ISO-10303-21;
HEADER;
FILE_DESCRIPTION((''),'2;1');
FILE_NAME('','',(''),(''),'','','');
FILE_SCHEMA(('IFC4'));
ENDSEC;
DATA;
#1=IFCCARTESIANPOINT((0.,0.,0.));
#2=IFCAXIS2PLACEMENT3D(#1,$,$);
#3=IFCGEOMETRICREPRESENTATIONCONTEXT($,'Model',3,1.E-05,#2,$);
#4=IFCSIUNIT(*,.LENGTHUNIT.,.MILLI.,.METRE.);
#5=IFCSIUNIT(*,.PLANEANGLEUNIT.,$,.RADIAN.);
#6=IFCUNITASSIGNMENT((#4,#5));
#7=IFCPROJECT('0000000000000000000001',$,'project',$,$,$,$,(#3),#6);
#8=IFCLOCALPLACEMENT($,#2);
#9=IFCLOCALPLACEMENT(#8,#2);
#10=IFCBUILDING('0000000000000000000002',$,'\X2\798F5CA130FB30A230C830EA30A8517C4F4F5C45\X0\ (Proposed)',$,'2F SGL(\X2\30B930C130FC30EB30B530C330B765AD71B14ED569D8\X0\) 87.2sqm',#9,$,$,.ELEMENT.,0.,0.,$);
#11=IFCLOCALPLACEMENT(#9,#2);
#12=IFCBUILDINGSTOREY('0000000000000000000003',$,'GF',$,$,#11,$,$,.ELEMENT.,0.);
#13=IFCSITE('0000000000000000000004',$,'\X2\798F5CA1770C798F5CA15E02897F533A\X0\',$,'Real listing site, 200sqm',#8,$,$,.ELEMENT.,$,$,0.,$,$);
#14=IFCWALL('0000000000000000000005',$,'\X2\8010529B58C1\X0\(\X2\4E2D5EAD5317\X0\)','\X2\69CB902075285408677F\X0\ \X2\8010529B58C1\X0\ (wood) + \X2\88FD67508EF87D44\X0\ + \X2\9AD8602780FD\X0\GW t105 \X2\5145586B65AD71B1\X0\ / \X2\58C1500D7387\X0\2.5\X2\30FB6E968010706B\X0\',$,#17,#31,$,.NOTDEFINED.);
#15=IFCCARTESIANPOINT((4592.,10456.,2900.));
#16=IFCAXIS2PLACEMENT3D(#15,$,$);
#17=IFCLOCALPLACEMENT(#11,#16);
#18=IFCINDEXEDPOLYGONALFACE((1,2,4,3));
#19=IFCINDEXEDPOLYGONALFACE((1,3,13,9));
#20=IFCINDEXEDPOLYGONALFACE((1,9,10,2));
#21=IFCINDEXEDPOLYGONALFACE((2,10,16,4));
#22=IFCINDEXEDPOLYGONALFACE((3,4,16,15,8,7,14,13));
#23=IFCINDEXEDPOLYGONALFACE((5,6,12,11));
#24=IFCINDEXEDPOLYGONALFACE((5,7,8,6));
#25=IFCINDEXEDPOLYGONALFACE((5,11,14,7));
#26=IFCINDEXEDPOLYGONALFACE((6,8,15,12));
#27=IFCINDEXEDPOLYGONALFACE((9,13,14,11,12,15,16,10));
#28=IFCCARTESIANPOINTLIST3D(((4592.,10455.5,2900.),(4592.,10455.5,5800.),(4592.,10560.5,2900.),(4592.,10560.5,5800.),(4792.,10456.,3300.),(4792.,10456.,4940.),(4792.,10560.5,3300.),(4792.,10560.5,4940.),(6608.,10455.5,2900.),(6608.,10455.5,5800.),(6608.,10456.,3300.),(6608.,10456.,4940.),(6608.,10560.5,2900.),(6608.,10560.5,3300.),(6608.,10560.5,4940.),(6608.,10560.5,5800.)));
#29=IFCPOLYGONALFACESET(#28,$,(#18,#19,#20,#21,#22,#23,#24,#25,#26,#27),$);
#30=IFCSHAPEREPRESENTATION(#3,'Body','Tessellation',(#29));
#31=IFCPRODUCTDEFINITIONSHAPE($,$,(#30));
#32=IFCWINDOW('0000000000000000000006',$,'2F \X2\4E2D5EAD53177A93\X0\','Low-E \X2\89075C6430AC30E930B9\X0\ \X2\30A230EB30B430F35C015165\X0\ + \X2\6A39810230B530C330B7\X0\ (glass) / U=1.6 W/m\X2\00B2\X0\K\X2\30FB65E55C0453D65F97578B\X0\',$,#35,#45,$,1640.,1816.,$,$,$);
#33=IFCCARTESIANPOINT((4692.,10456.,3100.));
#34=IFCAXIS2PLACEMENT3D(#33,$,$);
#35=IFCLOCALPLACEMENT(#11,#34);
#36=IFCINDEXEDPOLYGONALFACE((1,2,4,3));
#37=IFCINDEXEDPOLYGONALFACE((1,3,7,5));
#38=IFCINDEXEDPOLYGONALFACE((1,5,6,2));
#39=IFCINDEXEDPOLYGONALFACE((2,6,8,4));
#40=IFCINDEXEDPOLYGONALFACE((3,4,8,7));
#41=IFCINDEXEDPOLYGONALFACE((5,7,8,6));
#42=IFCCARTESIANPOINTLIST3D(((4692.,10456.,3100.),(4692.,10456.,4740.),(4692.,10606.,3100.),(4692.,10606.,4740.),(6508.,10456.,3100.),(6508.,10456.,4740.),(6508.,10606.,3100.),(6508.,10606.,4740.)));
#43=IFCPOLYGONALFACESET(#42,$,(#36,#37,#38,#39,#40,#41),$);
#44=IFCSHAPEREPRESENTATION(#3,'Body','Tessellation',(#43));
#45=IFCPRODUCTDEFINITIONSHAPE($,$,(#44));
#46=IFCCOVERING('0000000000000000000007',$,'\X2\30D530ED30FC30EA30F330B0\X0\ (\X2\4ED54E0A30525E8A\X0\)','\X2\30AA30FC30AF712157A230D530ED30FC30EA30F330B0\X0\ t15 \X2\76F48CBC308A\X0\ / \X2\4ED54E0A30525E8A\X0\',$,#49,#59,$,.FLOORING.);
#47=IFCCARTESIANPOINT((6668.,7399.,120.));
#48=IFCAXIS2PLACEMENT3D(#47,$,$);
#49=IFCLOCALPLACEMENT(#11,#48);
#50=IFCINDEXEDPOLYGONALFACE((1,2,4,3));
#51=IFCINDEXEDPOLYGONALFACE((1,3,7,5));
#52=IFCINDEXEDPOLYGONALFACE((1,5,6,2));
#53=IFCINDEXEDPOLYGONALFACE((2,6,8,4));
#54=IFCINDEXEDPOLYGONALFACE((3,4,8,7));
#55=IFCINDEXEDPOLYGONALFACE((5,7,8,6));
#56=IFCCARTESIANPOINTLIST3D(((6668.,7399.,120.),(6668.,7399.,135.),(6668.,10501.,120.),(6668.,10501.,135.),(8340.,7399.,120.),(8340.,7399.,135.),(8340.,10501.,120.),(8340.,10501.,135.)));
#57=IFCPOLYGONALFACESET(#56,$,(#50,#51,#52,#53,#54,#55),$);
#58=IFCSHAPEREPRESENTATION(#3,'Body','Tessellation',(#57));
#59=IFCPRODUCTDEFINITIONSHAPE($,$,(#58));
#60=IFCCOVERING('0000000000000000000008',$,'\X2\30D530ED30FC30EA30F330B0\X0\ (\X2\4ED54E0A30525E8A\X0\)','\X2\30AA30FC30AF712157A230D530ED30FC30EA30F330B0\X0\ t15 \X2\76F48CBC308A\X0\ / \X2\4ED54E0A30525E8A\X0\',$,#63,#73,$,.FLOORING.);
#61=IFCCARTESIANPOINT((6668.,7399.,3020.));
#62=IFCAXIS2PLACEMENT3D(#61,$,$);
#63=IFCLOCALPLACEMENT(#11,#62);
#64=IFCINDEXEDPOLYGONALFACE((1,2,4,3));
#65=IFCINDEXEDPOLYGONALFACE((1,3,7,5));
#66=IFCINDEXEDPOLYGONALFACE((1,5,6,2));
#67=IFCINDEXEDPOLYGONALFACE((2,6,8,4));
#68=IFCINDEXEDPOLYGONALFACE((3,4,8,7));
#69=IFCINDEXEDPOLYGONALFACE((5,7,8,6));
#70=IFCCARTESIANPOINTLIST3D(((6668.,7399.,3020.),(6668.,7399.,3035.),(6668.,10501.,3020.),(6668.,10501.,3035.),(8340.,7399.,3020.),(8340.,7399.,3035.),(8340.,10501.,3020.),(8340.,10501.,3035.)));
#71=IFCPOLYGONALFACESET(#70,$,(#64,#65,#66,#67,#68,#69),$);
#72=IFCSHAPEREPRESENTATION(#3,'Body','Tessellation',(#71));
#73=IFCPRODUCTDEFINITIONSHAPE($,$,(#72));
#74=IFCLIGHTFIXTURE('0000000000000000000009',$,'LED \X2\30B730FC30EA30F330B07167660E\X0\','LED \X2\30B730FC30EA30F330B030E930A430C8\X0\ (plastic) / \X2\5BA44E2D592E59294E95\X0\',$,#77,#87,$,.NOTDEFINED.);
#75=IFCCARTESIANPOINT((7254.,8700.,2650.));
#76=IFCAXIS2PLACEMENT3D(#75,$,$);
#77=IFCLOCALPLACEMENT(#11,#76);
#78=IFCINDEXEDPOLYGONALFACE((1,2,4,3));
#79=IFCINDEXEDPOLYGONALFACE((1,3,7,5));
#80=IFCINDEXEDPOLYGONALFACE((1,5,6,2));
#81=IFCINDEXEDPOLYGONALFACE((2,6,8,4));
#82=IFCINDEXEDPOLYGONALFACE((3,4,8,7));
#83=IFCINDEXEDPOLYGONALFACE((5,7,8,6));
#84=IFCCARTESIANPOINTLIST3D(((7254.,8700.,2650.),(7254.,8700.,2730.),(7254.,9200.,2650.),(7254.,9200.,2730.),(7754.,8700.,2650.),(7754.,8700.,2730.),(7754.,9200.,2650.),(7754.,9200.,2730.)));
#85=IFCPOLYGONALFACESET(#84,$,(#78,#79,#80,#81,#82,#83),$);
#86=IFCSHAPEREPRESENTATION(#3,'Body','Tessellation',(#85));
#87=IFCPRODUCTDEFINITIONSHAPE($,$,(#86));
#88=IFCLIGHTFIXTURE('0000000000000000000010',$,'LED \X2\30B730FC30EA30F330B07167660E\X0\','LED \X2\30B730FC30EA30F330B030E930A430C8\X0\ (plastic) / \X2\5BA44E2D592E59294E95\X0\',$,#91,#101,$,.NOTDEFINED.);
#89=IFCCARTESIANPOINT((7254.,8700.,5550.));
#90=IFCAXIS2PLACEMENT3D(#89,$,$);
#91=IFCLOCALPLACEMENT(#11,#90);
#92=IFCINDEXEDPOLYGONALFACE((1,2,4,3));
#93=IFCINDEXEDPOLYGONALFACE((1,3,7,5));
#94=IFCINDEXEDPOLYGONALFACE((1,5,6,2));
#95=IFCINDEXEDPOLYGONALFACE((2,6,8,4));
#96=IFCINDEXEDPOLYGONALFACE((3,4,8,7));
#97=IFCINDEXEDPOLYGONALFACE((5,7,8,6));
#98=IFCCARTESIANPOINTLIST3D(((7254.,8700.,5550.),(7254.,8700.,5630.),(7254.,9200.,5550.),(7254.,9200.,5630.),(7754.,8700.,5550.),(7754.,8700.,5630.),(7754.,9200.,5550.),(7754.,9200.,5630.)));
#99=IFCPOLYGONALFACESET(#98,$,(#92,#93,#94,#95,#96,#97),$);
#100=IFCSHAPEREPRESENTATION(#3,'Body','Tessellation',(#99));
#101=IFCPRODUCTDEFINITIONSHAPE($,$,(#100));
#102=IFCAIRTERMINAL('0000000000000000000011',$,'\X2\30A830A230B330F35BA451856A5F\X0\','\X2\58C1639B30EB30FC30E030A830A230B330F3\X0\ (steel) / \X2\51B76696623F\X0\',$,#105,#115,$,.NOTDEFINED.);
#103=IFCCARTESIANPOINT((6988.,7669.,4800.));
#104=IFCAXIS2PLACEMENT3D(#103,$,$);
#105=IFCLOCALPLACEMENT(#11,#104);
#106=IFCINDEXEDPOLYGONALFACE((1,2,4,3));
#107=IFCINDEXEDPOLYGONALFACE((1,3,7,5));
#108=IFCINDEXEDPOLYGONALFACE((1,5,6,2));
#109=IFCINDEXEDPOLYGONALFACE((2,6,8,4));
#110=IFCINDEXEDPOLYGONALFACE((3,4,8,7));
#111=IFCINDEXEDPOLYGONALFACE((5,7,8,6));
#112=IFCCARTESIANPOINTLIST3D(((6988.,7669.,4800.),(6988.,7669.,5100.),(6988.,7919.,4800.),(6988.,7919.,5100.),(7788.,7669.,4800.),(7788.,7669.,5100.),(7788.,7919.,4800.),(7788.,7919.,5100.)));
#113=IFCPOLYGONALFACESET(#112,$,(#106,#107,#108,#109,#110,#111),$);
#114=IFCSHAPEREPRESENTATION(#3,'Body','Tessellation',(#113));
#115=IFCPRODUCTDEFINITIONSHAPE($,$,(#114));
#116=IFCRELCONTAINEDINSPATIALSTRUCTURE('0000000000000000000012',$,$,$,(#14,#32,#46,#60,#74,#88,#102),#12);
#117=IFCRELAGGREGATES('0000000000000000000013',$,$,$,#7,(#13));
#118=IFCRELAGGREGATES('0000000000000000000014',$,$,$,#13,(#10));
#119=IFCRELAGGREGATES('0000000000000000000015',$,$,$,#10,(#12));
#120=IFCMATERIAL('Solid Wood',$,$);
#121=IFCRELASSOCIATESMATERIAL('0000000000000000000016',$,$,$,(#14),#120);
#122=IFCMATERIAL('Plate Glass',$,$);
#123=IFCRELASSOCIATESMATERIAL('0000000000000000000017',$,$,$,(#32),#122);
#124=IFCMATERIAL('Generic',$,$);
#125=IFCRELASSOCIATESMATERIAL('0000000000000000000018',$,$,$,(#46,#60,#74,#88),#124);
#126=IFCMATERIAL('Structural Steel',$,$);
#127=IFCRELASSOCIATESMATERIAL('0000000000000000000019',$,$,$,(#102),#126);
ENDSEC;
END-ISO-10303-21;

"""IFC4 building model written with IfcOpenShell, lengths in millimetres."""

from ifc_helpers import new_model, si_unit, frame, frame_2d, origin, place, context, project, spatial, rectangle, extrude, material, element, fill, save


model = new_model("IFC4")

# Units and contexts
model_context = context("Model", 3, precision=1e-05, world=origin())
ifc_project = project(units=[si_unit("LENGTHUNIT", "METRE", prefix="MILLI"), si_unit("PLANEANGLEUNIT", "RADIAN")], contexts=[model_context])

# Site, building, storey
site_placement = place(None, origin())
site = spatial("IfcSite", under=ifc_project, at=site_placement, Name="福岡県福岡市西区", ObjectType="Real listing site, 200sqm", CompositionType="ELEMENT", RefElevation=0.0)
building_placement = place(site_placement, origin())
building = spatial("IfcBuilding", under=site, at=building_placement, Name="福岡・アトリエ兼住居 (Proposed)", ObjectType="2F SGL(スチールサッシ断熱仕様) 87.2sqm", CompositionType="ELEMENT", ElevationOfRefHeight=0.0, ElevationOfTerrain=0.0)
storey_placement = place(building_placement, origin())
storey = spatial("IfcBuildingStorey", under=building, at=storey_placement, Name="GF", CompositionType="ELEMENT", Elevation=0.0)

# Shared definitions
ifc_material_1 = material(Name="Solid Wood")

# Wall, opening, window
ifc_material_2 = material(Name="Plate Glass")
wall_1_placement = place(storey_placement, frame((4592.0, 10456.0, 2900.0)))
wall_1 = element("IfcWall", 1, at=wall_1_placement, inside=storey, material=ifc_material_1, Name="耐力壁(中庭北)", Description="構造用合板 耐力壁 (wood) + 製材軸組 + 高性能GW t105 充填断熱 / 壁倍率2.5・準耐火", PredefinedType="NOTDEFINED", context=model_context, shape_type="SweptSolid", body=[
    extrude(rectangle(XDim=2016.0, YDim=105.0, at=frame_2d((1008.0, 52.0))), frame((4592.0, 10456.0, 2900.0)), (0.0, 0.0, 1.0), 2900.0),
])
opening_1_placement = place(storey_placement, frame((4692.0, 10456.0, 3100.0)))
opening_1 = element("IfcOpeningElement", 2, at=opening_1_placement, cuts=wall_1, PredefinedType="NOTDEFINED", context=model_context, shape_type="SweptSolid", body=[
    extrude(rectangle(XDim=1816.0, YDim=150.0, at=frame_2d((908.0, 75.0))), frame((4692.0, 10456.0, 3100.0)), (0.0, 0.0, 1.0), 1640.0),
])
window_1_placement = place(storey_placement, frame((4692.0, 10456.0, 3100.0)))
window_1 = element("IfcWindow", 3, at=window_1_placement, inside=storey, material=ifc_material_2, Name="2F 中庭北窓", Description="Low-E 複層ガラス アルゴン封入 + 樹脂サッシ (glass) / U=1.6 W/m²K・日射取得型", OverallHeight=1640.0, OverallWidth=1816.0, context=model_context, shape_type="SweptSolid", body=[
    extrude(rectangle(XDim=1816.0, YDim=150.0, at=frame_2d((908.0, 75.0))), frame((4692.0, 10456.0, 3100.0)), (0.0, 0.0, 1.0), 1640.0),
])
fill(opening_1, window_1)

# Coverings
ifc_material_3 = material(Name="Generic")
covering_1_placement = place(storey_placement, frame((6668.0, 7399.0, 120.0)))
element("IfcCovering", 4, at=covering_1_placement, inside=storey, material=ifc_material_3, Name="フローリング (仕上げ床)", Description="オーク無垢フローリング t15 直貼り / 仕上げ床", PredefinedType="FLOORING", context=model_context, shape_type="SweptSolid", body=[
    extrude(rectangle(XDim=1672.0, YDim=3102.0, at=frame_2d((836.0, 1551.0))), frame((6668.0, 7399.0, 120.0)), (0.0, 0.0, 1.0), 15.0),
])
covering_2_placement = place(storey_placement, frame((6668.0, 7399.0, 3020.0)))
element("IfcCovering", 5, at=covering_2_placement, inside=storey, material=ifc_material_3, Name="フローリング (仕上げ床)", Description="オーク無垢フローリング t15 直貼り / 仕上げ床", PredefinedType="FLOORING", context=model_context, shape_type="SweptSolid", body=[
    extrude(rectangle(XDim=1672.0, YDim=3102.0, at=frame_2d((836.0, 1551.0))), frame((6668.0, 7399.0, 3020.0)), (0.0, 0.0, 1.0), 15.0),
])

# Light fixtures
light_fixture_1_placement = place(storey_placement, frame((7254.0, 8700.0, 2650.0)))
element("IfcLightFixture", 6, at=light_fixture_1_placement, inside=storey, material=ifc_material_3, Name="LED シーリング照明", Description="LED シーリングライト (plastic) / 室中央天井", PredefinedType="NOTDEFINED", context=model_context, shape_type="SweptSolid", body=[
    extrude(rectangle(XDim=500.0, YDim=500.0, at=frame_2d((250.0, 250.0))), frame((7254.0, 8700.0, 2650.0)), (0.0, 0.0, 1.0), 80.0),
])
light_fixture_2_placement = place(storey_placement, frame((7254.0, 8700.0, 5550.0)))
element("IfcLightFixture", 7, at=light_fixture_2_placement, inside=storey, material=ifc_material_3, Name="LED シーリング照明", Description="LED シーリングライト (plastic) / 室中央天井", PredefinedType="NOTDEFINED", context=model_context, shape_type="SweptSolid", body=[
    extrude(rectangle(XDim=500.0, YDim=500.0, at=frame_2d((250.0, 250.0))), frame((7254.0, 8700.0, 5550.0)), (0.0, 0.0, 1.0), 80.0),
])

# Air terminal
ifc_material_4 = material(Name="Structural Steel")
air_terminal_placement = place(storey_placement, frame((6988.0, 7669.0, 4800.0)))
element("IfcAirTerminal", 8, at=air_terminal_placement, inside=storey, material=ifc_material_4, Name="エアコン室内機", Description="壁掛ルームエアコン (steel) / 冷暖房", PredefinedType="NOTDEFINED", context=model_context, shape_type="SweptSolid", body=[
    extrude(rectangle(XDim=800.0, YDim=250.0, at=frame_2d((400.0, 125.0))), frame((6988.0, 7669.0, 4800.0)), (0.0, 0.0, 1.0), 300.0),
])

save(model, "model.ifc")
